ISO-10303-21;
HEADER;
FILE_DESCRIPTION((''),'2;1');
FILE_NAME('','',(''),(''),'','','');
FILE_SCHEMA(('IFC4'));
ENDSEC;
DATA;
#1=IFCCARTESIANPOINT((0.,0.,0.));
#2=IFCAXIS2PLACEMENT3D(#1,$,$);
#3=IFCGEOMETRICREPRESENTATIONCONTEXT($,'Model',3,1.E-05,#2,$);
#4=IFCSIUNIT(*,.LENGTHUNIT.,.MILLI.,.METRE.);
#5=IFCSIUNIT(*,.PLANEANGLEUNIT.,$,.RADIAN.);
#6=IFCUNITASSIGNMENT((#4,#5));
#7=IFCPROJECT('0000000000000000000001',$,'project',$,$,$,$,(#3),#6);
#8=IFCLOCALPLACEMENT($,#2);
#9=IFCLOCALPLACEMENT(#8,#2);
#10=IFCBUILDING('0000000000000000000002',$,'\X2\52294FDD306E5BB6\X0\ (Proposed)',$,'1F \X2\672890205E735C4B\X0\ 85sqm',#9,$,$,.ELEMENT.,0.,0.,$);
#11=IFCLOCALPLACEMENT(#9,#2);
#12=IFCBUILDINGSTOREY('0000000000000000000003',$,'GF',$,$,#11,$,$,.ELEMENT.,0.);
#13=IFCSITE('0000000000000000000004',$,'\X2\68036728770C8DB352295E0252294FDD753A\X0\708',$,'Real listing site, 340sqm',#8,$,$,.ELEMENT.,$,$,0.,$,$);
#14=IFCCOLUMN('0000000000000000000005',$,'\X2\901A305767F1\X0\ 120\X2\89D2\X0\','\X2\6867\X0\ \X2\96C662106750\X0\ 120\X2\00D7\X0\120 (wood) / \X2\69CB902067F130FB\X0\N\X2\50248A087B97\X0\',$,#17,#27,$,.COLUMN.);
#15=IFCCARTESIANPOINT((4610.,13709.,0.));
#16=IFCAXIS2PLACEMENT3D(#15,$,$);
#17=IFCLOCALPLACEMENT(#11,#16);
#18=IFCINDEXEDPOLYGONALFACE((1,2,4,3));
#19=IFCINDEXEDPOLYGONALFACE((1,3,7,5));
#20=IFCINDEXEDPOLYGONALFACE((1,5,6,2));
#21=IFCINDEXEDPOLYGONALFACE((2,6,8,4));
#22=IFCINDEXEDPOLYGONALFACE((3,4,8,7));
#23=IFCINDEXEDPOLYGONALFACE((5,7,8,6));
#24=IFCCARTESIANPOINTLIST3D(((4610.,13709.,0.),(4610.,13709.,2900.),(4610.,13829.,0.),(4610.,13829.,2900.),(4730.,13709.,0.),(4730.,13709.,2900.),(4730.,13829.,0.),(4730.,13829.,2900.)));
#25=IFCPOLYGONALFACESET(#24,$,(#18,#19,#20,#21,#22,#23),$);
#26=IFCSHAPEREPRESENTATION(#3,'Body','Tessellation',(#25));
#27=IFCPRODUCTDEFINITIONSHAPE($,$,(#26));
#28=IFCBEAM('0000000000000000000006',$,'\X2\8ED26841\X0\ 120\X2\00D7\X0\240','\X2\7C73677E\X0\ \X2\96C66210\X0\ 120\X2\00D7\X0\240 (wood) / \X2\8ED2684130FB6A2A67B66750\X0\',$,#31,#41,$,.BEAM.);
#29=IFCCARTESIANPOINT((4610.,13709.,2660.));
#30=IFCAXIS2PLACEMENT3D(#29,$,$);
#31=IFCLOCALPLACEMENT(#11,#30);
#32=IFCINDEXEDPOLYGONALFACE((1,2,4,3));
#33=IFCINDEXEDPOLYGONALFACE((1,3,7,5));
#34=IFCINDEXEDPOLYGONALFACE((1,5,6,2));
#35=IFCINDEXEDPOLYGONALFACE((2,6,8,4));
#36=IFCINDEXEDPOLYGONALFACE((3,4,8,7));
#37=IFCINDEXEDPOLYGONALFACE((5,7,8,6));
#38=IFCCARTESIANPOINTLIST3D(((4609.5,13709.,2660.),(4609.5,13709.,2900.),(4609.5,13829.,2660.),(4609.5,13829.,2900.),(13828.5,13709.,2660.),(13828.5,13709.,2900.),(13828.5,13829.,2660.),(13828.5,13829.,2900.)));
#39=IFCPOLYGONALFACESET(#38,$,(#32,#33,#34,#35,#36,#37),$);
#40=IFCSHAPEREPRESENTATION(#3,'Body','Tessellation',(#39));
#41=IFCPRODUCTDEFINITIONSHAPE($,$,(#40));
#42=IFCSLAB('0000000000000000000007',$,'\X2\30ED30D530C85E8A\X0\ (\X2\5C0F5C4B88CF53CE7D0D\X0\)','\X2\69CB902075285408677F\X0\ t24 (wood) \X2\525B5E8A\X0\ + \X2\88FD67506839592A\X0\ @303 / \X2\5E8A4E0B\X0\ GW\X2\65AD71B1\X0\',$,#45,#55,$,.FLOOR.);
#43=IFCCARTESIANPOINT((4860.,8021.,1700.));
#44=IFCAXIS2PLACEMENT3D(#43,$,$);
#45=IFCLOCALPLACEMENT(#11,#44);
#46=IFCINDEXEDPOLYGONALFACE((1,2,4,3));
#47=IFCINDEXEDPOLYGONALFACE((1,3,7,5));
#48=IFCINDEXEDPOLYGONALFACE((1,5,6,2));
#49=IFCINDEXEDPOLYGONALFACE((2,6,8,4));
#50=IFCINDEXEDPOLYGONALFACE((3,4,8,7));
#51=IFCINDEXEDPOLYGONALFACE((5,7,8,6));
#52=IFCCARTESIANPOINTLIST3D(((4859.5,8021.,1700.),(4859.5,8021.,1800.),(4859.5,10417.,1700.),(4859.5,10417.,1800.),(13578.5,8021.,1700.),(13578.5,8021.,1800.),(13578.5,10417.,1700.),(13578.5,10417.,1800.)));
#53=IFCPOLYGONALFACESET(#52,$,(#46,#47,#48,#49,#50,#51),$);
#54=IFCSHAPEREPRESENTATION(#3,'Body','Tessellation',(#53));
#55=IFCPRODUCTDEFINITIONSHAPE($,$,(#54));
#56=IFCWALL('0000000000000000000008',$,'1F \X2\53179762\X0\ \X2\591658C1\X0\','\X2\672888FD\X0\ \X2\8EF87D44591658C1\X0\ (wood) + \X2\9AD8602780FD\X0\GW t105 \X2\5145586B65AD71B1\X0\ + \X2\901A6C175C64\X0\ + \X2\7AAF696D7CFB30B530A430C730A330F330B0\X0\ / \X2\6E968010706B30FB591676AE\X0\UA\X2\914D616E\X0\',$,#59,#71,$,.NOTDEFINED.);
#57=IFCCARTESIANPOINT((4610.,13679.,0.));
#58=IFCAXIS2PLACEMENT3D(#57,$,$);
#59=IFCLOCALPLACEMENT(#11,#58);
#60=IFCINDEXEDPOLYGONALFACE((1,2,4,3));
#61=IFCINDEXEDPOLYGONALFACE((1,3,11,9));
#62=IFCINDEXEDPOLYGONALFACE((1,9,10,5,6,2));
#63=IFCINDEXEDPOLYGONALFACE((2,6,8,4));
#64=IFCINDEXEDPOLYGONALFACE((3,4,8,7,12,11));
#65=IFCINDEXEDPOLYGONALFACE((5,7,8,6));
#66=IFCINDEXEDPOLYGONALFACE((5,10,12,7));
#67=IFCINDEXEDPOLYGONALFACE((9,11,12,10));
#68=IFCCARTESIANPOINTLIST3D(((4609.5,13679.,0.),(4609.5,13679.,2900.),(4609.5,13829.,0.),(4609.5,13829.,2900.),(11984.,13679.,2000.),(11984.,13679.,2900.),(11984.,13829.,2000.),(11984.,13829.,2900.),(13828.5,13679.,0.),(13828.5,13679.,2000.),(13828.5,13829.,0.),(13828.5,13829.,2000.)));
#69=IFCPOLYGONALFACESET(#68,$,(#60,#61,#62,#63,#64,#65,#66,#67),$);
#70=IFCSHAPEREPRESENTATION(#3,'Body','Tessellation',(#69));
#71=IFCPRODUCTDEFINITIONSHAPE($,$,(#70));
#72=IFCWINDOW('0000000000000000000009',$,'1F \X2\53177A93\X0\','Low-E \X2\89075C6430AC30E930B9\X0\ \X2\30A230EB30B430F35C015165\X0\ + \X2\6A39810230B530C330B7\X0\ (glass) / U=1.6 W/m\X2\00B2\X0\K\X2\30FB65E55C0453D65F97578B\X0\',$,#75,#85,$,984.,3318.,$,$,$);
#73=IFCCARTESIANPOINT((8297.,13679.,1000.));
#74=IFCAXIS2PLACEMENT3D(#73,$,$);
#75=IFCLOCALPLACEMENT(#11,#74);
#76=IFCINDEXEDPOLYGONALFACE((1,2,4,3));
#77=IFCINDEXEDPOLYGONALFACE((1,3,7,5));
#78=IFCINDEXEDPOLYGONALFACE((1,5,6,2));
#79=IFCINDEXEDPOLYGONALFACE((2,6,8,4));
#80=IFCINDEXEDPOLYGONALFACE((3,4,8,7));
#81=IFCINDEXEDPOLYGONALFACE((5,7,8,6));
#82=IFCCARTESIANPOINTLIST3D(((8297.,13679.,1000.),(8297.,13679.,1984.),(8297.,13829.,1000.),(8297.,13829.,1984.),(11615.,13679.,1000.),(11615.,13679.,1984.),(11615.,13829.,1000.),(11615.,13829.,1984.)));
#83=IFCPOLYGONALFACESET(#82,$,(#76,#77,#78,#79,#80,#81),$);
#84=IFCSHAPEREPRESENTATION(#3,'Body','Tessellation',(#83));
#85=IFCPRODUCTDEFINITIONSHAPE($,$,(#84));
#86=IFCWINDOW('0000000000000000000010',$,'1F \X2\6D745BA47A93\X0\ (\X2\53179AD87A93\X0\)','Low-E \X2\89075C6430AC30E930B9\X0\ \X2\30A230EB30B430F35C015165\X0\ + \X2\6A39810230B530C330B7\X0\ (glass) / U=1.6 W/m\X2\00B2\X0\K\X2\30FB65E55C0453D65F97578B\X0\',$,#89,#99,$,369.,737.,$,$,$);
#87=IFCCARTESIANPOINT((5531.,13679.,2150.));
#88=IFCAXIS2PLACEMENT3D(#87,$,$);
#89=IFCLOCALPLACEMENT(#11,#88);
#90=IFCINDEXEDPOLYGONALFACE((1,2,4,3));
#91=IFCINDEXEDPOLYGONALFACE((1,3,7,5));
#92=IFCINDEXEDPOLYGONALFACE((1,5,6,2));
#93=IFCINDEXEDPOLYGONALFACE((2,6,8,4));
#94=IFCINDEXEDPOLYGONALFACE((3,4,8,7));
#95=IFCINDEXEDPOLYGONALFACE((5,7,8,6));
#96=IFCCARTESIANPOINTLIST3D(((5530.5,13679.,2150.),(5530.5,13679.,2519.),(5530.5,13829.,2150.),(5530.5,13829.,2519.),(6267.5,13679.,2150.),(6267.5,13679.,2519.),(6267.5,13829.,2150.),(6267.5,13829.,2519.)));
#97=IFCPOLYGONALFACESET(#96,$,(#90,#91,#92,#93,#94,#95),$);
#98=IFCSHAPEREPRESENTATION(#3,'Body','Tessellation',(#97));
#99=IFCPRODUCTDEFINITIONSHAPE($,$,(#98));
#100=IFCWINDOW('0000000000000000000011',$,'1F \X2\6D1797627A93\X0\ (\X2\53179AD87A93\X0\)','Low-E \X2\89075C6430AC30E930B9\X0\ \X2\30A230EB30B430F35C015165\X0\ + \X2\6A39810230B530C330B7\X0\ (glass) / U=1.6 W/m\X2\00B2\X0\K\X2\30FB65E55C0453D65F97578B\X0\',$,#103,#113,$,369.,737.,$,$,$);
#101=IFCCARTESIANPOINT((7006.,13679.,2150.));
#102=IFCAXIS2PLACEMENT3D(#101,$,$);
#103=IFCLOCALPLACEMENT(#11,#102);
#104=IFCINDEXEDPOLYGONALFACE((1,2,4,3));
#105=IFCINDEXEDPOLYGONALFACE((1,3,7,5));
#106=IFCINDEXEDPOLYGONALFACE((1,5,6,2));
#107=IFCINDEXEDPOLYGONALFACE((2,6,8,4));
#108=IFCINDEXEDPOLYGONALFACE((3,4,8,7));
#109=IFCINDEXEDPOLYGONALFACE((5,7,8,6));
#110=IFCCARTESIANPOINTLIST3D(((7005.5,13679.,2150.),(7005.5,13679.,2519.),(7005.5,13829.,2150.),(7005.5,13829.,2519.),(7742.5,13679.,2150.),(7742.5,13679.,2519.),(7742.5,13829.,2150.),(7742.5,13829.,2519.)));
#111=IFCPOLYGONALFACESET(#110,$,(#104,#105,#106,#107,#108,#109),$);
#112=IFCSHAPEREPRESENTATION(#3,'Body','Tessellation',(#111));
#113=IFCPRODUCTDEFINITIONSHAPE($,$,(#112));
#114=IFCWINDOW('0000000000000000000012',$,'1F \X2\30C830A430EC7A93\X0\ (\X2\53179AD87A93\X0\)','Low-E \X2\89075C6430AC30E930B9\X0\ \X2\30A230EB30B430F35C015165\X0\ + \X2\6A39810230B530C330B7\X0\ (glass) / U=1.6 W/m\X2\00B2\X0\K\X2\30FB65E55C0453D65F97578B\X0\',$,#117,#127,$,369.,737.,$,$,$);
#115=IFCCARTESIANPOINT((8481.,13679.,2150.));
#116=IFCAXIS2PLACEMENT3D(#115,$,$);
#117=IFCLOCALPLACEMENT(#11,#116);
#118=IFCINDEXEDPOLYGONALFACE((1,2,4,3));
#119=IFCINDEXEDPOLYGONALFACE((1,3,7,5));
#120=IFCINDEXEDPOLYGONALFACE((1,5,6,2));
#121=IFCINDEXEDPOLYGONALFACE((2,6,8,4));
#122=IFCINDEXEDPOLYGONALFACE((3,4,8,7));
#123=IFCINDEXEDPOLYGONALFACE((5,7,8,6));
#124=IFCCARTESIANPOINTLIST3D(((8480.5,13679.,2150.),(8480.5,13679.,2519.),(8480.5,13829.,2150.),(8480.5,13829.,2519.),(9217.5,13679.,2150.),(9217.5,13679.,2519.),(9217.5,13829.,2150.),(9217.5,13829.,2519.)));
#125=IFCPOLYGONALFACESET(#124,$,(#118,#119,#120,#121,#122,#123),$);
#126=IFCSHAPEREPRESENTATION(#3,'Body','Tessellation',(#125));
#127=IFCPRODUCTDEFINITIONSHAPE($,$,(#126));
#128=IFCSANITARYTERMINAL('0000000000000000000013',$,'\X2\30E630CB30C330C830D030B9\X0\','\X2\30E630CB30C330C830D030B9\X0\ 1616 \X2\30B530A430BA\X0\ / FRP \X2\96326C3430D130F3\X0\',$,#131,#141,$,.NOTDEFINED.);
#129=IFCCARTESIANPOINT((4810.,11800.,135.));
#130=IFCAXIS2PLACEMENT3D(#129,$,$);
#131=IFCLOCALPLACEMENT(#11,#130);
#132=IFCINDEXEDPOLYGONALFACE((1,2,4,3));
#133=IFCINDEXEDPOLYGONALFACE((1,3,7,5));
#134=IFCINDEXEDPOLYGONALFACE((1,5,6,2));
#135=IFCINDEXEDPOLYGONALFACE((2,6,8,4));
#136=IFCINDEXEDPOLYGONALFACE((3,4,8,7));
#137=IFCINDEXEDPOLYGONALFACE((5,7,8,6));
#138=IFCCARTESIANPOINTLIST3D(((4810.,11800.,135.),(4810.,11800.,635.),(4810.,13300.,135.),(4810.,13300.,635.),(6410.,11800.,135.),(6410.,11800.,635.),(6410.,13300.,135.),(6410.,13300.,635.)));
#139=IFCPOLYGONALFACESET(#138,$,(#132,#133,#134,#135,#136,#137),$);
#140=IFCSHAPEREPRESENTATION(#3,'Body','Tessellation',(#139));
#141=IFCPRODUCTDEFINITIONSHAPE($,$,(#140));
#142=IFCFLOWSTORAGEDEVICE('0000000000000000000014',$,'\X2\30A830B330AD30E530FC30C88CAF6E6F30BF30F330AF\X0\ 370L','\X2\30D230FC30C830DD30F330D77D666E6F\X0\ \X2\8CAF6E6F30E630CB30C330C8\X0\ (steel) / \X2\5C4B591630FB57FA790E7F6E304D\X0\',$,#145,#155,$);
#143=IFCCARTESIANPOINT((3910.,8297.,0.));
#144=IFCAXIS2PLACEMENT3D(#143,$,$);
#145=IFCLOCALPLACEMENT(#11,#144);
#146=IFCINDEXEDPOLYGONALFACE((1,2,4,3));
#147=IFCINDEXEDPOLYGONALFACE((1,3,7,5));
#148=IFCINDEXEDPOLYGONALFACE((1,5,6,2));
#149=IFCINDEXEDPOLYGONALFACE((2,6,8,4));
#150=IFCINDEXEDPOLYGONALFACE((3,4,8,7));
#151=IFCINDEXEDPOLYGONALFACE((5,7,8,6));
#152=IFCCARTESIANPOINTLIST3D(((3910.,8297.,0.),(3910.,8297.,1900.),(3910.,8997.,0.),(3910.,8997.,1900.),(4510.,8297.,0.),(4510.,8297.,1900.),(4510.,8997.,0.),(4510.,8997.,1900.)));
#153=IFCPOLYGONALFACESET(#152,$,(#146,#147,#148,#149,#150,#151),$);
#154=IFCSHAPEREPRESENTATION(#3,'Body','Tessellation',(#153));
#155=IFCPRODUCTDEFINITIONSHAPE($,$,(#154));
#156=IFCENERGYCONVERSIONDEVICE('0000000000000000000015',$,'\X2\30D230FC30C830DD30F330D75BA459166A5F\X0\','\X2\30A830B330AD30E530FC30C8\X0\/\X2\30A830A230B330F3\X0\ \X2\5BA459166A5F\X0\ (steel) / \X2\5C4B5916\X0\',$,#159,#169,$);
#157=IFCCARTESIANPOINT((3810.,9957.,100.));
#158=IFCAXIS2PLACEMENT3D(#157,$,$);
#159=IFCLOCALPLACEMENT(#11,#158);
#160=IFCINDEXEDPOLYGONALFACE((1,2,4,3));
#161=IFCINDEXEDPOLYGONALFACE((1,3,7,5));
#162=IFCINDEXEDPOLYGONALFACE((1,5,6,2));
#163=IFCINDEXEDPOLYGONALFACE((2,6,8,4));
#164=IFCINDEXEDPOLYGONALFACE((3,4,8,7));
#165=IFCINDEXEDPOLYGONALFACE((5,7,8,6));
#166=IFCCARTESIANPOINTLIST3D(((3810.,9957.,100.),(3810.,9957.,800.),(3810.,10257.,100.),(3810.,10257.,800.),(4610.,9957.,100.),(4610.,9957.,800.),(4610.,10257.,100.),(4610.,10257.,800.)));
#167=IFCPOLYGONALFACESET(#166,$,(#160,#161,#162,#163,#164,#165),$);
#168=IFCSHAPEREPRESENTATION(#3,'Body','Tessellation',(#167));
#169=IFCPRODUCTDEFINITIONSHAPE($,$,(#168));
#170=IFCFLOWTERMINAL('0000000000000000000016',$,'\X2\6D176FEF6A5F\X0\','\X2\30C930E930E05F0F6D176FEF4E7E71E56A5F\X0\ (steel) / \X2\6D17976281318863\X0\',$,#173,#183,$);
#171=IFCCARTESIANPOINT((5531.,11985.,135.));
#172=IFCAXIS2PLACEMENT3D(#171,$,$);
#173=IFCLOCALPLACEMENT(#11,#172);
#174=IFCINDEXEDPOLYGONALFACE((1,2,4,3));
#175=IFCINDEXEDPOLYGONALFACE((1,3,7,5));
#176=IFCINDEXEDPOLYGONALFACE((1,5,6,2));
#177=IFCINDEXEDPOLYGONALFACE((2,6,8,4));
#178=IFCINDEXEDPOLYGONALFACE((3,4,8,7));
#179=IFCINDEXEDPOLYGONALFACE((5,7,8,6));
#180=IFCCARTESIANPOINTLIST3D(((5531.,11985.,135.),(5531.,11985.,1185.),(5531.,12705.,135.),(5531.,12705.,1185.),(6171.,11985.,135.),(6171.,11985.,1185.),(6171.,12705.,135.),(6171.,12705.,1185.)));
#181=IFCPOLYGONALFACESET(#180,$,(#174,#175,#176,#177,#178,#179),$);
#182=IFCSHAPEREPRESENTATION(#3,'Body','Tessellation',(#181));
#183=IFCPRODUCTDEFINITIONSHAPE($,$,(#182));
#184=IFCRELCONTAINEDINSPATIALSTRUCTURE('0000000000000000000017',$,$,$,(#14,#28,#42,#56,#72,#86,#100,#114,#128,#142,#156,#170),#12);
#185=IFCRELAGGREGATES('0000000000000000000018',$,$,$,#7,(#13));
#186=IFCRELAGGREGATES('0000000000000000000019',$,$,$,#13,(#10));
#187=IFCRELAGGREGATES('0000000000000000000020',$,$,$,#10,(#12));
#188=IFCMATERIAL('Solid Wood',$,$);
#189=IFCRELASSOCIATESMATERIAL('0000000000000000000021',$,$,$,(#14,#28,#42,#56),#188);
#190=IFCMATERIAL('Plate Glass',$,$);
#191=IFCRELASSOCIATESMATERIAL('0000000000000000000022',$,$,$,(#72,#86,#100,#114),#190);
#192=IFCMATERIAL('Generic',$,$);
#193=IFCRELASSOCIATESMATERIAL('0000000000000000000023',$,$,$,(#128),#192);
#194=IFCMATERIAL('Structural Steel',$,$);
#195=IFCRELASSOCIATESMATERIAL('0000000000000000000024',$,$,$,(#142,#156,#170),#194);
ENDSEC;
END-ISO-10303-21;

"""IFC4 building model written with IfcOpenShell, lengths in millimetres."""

from ifc_helpers import new_model, si_unit, frame, frame_2d, origin, place, context, project, spatial, rectangle, extrude, material, element, fill, save


model = new_model("IFC4")

# Units and contexts
model_context = context("Model", 3, precision=1e-05, world=origin())
ifc_project = project(units=[si_unit("LENGTHUNIT", "METRE", prefix="MILLI"), si_unit("PLANEANGLEUNIT", "RADIAN")], contexts=[model_context])

# Site, building, storey
site_placement = place(None, origin())
site = spatial("IfcSite", under=ifc_project, at=site_placement, Name="栃木県足利市利保町708", ObjectType="Real listing site, 340sqm", CompositionType="ELEMENT", RefElevation=0.0)
building_placement = place(site_placement, origin())
building = spatial("IfcBuilding", under=site, at=building_placement, Name="利保の家 (Proposed)", ObjectType="1F 木造平屋 85sqm", CompositionType="ELEMENT", ElevationOfRefHeight=0.0, ElevationOfTerrain=0.0)
storey_placement = place(building_placement, origin())
storey = spatial("IfcBuildingStorey", under=building, at=storey_placement, Name="GF", CompositionType="ELEMENT", Elevation=0.0)

# Column
ifc_material_1 = material(Name="Solid Wood")
column_1_placement = place(storey_placement, frame((4610.0, 13709.0, 0.0)))
element("IfcColumn", 1, at=column_1_placement, inside=storey, material=ifc_material_1, Name="通し柱 120角", Description="桧 集成材 120×120 (wood) / 構造柱・N値計算", PredefinedType="COLUMN", context=model_context, shape_type="SweptSolid", body=[
    extrude(rectangle(XDim=120.0, YDim=120.0, at=frame_2d((60.0, 60.0))), frame((4610.0, 13709.0, 0.0)), (0.0, 0.0, 1.0), 2900.0),
])

# Beam
beam_1_placement = place(storey_placement, frame((4610.0, 13709.0, 2660.0)))
element("IfcBeam", 2, at=beam_1_placement, inside=storey, material=ifc_material_1, Name="軒桁 120×240", Description="米松 集成 120×240 (wood) / 軒桁・横架材", PredefinedType="BEAM", context=model_context, shape_type="SweptSolid", body=[
    extrude(rectangle(XDim=9219.0, YDim=120.0, at=frame_2d((4609.0, 60.0))), frame((4610.0, 13709.0, 2660.0)), (0.0, 0.0, 1.0), 240.0),
])

# Slab
slab_placement = place(storey_placement, frame((4860.0, 8021.0, 1700.0)))
element("IfcSlab", 3, at=slab_placement, inside=storey, material=ifc_material_1, Name="ロフト床 (小屋裏収納)", Description="構造用合板 t24 (wood) 剛床 + 製材根太 @303 / 床下 GW断熱", PredefinedType="FLOOR", context=model_context, shape_type="SweptSolid", body=[
    extrude(rectangle(XDim=8719.0, YDim=2396.0, at=frame_2d((4359.0, 1198.0))), frame((4860.0, 8021.0, 1700.0)), (0.0, 0.0, 1.0), 100.0),
])

# Wall, openings, windows
wall_1_placement = place(storey_placement, frame((4610.0, 13679.0, 0.0)))
wall_1 = element("IfcWall", 4, at=wall_1_placement, inside=storey, material=ifc_material_1, Name="1F 北面 外壁", Description="木製 軸組外壁 (wood) + 高性能GW t105 充填断熱 + 通気層 + 窯業系サイディング / 準耐火・外皮UA配慮", PredefinedType="NOTDEFINED", context=model_context, shape_type="SweptSolid", body=[
    extrude(rectangle(XDim=9219.0, YDim=150.0, at=frame_2d((4609.0, 75.0))), frame((4610.0, 13679.0, 0.0)), (0.0, 0.0, 1.0), 2900.0),
])
opening_1_placement = place(storey_placement, frame((8297.0, 13679.0, 1000.0)))
opening_1 = element("IfcOpeningElement", 5, at=opening_1_placement, cuts=wall_1, PredefinedType="NOTDEFINED", context=model_context, shape_type="SweptSolid", body=[
    extrude(rectangle(XDim=3318.0, YDim=150.0, at=frame_2d((1659.0, 75.0))), frame((8297.0, 13679.0, 1000.0)), (0.0, 0.0, 1.0), 984.0),
])
opening_2_placement = place(storey_placement, frame((5531.0, 13679.0, 2150.0)))
opening_2 = element("IfcOpeningElement", 6, at=opening_2_placement, cuts=wall_1, PredefinedType="NOTDEFINED", context=model_context, shape_type="SweptSolid", body=[
    extrude(rectangle(XDim=737.0, YDim=150.0, at=frame_2d((368.0, 75.0))), frame((5531.0, 13679.0, 2150.0)), (0.0, 0.0, 1.0), 369.0),
])
opening_3_placement = place(storey_placement, frame((7006.0, 13679.0, 2150.0)))
opening_3 = element("IfcOpeningElement", 7, at=opening_3_placement, cuts=wall_1, PredefinedType="NOTDEFINED", context=model_context, shape_type="SweptSolid", body=[
    extrude(rectangle(XDim=737.0, YDim=150.0, at=frame_2d((368.0, 75.0))), frame((7006.0, 13679.0, 2150.0)), (0.0, 0.0, 1.0), 369.0),
])
opening_4_placement = place(storey_placement, frame((8481.0, 13679.0, 2150.0)))
opening_4 = element("IfcOpeningElement", 8, at=opening_4_placement, cuts=wall_1, PredefinedType="NOTDEFINED", context=model_context, shape_type="SweptSolid", body=[
    extrude(rectangle(XDim=737.0, YDim=150.0, at=frame_2d((368.0, 75.0))), frame((8481.0, 13679.0, 2150.0)), (0.0, 0.0, 1.0), 369.0),
])
ifc_material_2 = material(Name="Plate Glass")
window_1_placement = place(storey_placement, frame((8297.0, 13679.0, 1000.0)))
window_1 = element("IfcWindow", 9, at=window_1_placement, inside=storey, material=ifc_material_2, Name="1F 北窓", Description="Low-E 複層ガラス アルゴン封入 + 樹脂サッシ (glass) / U=1.6 W/m²K・日射取得型", OverallHeight=984.0, OverallWidth=3318.0, context=model_context, shape_type="SweptSolid", body=[
    extrude(rectangle(XDim=3318.0, YDim=150.0, at=frame_2d((1659.0, 75.0))), frame((8297.0, 13679.0, 1000.0)), (0.0, 0.0, 1.0), 984.0),
])
fill(opening_1, window_1)
window_2_placement = place(storey_placement, frame((5531.0, 13679.0, 2150.0)))
window_2 = element("IfcWindow", 10, at=window_2_placement, inside=storey, material=ifc_material_2, Name="1F 浴室窓 (北高窓)", Description="Low-E 複層ガラス アルゴン封入 + 樹脂サッシ (glass) / U=1.6 W/m²K・日射取得型", OverallHeight=369.0, OverallWidth=737.0, context=model_context, shape_type="SweptSolid", body=[
    extrude(rectangle(XDim=737.0, YDim=150.0, at=frame_2d((368.0, 75.0))), frame((5531.0, 13679.0, 2150.0)), (0.0, 0.0, 1.0), 369.0),
])
fill(opening_2, window_2)
window_3_placement = place(storey_placement, frame((7006.0, 13679.0, 2150.0)))
window_3 = element("IfcWindow", 11, at=window_3_placement, inside=storey, material=ifc_material_2, Name="1F 洗面窓 (北高窓)", Description="Low-E 複層ガラス アルゴン封入 + 樹脂サッシ (glass) / U=1.6 W/m²K・日射取得型", OverallHeight=369.0, OverallWidth=737.0, context=model_context, shape_type="SweptSolid", body=[
    extrude(rectangle(XDim=737.0, YDim=150.0, at=frame_2d((368.0, 75.0))), frame((7006.0, 13679.0, 2150.0)), (0.0, 0.0, 1.0), 369.0),
])
fill(opening_3, window_3)
window_4_placement = place(storey_placement, frame((8481.0, 13679.0, 2150.0)))
window_4 = element("IfcWindow", 12, at=window_4_placement, inside=storey, material=ifc_material_2, Name="1F トイレ窓 (北高窓)", Description="Low-E 複層ガラス アルゴン封入 + 樹脂サッシ (glass) / U=1.6 W/m²K・日射取得型", OverallHeight=369.0, OverallWidth=737.0, context=model_context, shape_type="SweptSolid", body=[
    extrude(rectangle(XDim=737.0, YDim=150.0, at=frame_2d((368.0, 75.0))), frame((8481.0, 13679.0, 2150.0)), (0.0, 0.0, 1.0), 369.0),
])
fill(opening_4, window_4)

# Shared definitions
ifc_material_3 = material(Name="Structural Steel")

# Sanitary terminal
ifc_material_4 = material(Name="Generic")
sanitary_terminal_placement = place(storey_placement, frame((4810.0, 11800.0, 135.0)))
element("IfcSanitaryTerminal", 13, at=sanitary_terminal_placement, inside=storey, material=ifc_material_4, Name="ユニットバス", Description="ユニットバス 1616 サイズ / FRP 防水パン", PredefinedType="NOTDEFINED", context=model_context, shape_type="SweptSolid", body=[
    extrude(rectangle(XDim=1600.0, YDim=1500.0, at=frame_2d((800.0, 750.0))), frame((4810.0, 11800.0, 135.0)), (0.0, 0.0, 1.0), 500.0),
])

# Flow storage device
flow_storage_device_placement = place(storey_placement, frame((3910.0, 8297.0, 0.0)))
element("IfcFlowStorageDevice", 14, at=flow_storage_device_placement, inside=storey, material=ifc_material_3, Name="エコキュート貯湯タンク 370L", Description="ヒートポンプ給湯 貯湯ユニット (steel) / 屋外・基礎置き", context=model_context, shape_type="SweptSolid", body=[
    extrude(rectangle(XDim=600.0, YDim=700.0, at=frame_2d((300.0, 350.0))), frame((3910.0, 8297.0, 0.0)), (0.0, 0.0, 1.0), 1900.0),
])

# Energy conversion device
energy_conversion_device_placement = place(storey_placement, frame((3810.0, 9957.0, 100.0)))
element("IfcEnergyConversionDevice", 15, at=energy_conversion_device_placement, inside=storey, material=ifc_material_3, Name="ヒートポンプ室外機", Description="エコキュート/エアコン 室外機 (steel) / 屋外", context=model_context, shape_type="SweptSolid", body=[
    extrude(rectangle(XDim=800.0, YDim=300.0, at=frame_2d((400.0, 150.0))), frame((3810.0, 9957.0, 100.0)), (0.0, 0.0, 1.0), 700.0),
])

# Flow terminal
flow_terminal_placement = place(storey_placement, frame((5531.0, 11985.0, 135.0)))
element("IfcFlowTerminal", 16, at=flow_terminal_placement, inside=storey, material=ifc_material_3, Name="洗濯機", Description="ドラム式洗濯乾燥機 (steel) / 洗面脱衣", context=model_context, shape_type="SweptSolid", body=[
    extrude(rectangle(XDim=640.0, YDim=720.0, at=frame_2d((320.0, 360.0))), frame((5531.0, 11985.0, 135.0)), (0.0, 0.0, 1.0), 1050.0),
])

save(model, "model.ifc")
